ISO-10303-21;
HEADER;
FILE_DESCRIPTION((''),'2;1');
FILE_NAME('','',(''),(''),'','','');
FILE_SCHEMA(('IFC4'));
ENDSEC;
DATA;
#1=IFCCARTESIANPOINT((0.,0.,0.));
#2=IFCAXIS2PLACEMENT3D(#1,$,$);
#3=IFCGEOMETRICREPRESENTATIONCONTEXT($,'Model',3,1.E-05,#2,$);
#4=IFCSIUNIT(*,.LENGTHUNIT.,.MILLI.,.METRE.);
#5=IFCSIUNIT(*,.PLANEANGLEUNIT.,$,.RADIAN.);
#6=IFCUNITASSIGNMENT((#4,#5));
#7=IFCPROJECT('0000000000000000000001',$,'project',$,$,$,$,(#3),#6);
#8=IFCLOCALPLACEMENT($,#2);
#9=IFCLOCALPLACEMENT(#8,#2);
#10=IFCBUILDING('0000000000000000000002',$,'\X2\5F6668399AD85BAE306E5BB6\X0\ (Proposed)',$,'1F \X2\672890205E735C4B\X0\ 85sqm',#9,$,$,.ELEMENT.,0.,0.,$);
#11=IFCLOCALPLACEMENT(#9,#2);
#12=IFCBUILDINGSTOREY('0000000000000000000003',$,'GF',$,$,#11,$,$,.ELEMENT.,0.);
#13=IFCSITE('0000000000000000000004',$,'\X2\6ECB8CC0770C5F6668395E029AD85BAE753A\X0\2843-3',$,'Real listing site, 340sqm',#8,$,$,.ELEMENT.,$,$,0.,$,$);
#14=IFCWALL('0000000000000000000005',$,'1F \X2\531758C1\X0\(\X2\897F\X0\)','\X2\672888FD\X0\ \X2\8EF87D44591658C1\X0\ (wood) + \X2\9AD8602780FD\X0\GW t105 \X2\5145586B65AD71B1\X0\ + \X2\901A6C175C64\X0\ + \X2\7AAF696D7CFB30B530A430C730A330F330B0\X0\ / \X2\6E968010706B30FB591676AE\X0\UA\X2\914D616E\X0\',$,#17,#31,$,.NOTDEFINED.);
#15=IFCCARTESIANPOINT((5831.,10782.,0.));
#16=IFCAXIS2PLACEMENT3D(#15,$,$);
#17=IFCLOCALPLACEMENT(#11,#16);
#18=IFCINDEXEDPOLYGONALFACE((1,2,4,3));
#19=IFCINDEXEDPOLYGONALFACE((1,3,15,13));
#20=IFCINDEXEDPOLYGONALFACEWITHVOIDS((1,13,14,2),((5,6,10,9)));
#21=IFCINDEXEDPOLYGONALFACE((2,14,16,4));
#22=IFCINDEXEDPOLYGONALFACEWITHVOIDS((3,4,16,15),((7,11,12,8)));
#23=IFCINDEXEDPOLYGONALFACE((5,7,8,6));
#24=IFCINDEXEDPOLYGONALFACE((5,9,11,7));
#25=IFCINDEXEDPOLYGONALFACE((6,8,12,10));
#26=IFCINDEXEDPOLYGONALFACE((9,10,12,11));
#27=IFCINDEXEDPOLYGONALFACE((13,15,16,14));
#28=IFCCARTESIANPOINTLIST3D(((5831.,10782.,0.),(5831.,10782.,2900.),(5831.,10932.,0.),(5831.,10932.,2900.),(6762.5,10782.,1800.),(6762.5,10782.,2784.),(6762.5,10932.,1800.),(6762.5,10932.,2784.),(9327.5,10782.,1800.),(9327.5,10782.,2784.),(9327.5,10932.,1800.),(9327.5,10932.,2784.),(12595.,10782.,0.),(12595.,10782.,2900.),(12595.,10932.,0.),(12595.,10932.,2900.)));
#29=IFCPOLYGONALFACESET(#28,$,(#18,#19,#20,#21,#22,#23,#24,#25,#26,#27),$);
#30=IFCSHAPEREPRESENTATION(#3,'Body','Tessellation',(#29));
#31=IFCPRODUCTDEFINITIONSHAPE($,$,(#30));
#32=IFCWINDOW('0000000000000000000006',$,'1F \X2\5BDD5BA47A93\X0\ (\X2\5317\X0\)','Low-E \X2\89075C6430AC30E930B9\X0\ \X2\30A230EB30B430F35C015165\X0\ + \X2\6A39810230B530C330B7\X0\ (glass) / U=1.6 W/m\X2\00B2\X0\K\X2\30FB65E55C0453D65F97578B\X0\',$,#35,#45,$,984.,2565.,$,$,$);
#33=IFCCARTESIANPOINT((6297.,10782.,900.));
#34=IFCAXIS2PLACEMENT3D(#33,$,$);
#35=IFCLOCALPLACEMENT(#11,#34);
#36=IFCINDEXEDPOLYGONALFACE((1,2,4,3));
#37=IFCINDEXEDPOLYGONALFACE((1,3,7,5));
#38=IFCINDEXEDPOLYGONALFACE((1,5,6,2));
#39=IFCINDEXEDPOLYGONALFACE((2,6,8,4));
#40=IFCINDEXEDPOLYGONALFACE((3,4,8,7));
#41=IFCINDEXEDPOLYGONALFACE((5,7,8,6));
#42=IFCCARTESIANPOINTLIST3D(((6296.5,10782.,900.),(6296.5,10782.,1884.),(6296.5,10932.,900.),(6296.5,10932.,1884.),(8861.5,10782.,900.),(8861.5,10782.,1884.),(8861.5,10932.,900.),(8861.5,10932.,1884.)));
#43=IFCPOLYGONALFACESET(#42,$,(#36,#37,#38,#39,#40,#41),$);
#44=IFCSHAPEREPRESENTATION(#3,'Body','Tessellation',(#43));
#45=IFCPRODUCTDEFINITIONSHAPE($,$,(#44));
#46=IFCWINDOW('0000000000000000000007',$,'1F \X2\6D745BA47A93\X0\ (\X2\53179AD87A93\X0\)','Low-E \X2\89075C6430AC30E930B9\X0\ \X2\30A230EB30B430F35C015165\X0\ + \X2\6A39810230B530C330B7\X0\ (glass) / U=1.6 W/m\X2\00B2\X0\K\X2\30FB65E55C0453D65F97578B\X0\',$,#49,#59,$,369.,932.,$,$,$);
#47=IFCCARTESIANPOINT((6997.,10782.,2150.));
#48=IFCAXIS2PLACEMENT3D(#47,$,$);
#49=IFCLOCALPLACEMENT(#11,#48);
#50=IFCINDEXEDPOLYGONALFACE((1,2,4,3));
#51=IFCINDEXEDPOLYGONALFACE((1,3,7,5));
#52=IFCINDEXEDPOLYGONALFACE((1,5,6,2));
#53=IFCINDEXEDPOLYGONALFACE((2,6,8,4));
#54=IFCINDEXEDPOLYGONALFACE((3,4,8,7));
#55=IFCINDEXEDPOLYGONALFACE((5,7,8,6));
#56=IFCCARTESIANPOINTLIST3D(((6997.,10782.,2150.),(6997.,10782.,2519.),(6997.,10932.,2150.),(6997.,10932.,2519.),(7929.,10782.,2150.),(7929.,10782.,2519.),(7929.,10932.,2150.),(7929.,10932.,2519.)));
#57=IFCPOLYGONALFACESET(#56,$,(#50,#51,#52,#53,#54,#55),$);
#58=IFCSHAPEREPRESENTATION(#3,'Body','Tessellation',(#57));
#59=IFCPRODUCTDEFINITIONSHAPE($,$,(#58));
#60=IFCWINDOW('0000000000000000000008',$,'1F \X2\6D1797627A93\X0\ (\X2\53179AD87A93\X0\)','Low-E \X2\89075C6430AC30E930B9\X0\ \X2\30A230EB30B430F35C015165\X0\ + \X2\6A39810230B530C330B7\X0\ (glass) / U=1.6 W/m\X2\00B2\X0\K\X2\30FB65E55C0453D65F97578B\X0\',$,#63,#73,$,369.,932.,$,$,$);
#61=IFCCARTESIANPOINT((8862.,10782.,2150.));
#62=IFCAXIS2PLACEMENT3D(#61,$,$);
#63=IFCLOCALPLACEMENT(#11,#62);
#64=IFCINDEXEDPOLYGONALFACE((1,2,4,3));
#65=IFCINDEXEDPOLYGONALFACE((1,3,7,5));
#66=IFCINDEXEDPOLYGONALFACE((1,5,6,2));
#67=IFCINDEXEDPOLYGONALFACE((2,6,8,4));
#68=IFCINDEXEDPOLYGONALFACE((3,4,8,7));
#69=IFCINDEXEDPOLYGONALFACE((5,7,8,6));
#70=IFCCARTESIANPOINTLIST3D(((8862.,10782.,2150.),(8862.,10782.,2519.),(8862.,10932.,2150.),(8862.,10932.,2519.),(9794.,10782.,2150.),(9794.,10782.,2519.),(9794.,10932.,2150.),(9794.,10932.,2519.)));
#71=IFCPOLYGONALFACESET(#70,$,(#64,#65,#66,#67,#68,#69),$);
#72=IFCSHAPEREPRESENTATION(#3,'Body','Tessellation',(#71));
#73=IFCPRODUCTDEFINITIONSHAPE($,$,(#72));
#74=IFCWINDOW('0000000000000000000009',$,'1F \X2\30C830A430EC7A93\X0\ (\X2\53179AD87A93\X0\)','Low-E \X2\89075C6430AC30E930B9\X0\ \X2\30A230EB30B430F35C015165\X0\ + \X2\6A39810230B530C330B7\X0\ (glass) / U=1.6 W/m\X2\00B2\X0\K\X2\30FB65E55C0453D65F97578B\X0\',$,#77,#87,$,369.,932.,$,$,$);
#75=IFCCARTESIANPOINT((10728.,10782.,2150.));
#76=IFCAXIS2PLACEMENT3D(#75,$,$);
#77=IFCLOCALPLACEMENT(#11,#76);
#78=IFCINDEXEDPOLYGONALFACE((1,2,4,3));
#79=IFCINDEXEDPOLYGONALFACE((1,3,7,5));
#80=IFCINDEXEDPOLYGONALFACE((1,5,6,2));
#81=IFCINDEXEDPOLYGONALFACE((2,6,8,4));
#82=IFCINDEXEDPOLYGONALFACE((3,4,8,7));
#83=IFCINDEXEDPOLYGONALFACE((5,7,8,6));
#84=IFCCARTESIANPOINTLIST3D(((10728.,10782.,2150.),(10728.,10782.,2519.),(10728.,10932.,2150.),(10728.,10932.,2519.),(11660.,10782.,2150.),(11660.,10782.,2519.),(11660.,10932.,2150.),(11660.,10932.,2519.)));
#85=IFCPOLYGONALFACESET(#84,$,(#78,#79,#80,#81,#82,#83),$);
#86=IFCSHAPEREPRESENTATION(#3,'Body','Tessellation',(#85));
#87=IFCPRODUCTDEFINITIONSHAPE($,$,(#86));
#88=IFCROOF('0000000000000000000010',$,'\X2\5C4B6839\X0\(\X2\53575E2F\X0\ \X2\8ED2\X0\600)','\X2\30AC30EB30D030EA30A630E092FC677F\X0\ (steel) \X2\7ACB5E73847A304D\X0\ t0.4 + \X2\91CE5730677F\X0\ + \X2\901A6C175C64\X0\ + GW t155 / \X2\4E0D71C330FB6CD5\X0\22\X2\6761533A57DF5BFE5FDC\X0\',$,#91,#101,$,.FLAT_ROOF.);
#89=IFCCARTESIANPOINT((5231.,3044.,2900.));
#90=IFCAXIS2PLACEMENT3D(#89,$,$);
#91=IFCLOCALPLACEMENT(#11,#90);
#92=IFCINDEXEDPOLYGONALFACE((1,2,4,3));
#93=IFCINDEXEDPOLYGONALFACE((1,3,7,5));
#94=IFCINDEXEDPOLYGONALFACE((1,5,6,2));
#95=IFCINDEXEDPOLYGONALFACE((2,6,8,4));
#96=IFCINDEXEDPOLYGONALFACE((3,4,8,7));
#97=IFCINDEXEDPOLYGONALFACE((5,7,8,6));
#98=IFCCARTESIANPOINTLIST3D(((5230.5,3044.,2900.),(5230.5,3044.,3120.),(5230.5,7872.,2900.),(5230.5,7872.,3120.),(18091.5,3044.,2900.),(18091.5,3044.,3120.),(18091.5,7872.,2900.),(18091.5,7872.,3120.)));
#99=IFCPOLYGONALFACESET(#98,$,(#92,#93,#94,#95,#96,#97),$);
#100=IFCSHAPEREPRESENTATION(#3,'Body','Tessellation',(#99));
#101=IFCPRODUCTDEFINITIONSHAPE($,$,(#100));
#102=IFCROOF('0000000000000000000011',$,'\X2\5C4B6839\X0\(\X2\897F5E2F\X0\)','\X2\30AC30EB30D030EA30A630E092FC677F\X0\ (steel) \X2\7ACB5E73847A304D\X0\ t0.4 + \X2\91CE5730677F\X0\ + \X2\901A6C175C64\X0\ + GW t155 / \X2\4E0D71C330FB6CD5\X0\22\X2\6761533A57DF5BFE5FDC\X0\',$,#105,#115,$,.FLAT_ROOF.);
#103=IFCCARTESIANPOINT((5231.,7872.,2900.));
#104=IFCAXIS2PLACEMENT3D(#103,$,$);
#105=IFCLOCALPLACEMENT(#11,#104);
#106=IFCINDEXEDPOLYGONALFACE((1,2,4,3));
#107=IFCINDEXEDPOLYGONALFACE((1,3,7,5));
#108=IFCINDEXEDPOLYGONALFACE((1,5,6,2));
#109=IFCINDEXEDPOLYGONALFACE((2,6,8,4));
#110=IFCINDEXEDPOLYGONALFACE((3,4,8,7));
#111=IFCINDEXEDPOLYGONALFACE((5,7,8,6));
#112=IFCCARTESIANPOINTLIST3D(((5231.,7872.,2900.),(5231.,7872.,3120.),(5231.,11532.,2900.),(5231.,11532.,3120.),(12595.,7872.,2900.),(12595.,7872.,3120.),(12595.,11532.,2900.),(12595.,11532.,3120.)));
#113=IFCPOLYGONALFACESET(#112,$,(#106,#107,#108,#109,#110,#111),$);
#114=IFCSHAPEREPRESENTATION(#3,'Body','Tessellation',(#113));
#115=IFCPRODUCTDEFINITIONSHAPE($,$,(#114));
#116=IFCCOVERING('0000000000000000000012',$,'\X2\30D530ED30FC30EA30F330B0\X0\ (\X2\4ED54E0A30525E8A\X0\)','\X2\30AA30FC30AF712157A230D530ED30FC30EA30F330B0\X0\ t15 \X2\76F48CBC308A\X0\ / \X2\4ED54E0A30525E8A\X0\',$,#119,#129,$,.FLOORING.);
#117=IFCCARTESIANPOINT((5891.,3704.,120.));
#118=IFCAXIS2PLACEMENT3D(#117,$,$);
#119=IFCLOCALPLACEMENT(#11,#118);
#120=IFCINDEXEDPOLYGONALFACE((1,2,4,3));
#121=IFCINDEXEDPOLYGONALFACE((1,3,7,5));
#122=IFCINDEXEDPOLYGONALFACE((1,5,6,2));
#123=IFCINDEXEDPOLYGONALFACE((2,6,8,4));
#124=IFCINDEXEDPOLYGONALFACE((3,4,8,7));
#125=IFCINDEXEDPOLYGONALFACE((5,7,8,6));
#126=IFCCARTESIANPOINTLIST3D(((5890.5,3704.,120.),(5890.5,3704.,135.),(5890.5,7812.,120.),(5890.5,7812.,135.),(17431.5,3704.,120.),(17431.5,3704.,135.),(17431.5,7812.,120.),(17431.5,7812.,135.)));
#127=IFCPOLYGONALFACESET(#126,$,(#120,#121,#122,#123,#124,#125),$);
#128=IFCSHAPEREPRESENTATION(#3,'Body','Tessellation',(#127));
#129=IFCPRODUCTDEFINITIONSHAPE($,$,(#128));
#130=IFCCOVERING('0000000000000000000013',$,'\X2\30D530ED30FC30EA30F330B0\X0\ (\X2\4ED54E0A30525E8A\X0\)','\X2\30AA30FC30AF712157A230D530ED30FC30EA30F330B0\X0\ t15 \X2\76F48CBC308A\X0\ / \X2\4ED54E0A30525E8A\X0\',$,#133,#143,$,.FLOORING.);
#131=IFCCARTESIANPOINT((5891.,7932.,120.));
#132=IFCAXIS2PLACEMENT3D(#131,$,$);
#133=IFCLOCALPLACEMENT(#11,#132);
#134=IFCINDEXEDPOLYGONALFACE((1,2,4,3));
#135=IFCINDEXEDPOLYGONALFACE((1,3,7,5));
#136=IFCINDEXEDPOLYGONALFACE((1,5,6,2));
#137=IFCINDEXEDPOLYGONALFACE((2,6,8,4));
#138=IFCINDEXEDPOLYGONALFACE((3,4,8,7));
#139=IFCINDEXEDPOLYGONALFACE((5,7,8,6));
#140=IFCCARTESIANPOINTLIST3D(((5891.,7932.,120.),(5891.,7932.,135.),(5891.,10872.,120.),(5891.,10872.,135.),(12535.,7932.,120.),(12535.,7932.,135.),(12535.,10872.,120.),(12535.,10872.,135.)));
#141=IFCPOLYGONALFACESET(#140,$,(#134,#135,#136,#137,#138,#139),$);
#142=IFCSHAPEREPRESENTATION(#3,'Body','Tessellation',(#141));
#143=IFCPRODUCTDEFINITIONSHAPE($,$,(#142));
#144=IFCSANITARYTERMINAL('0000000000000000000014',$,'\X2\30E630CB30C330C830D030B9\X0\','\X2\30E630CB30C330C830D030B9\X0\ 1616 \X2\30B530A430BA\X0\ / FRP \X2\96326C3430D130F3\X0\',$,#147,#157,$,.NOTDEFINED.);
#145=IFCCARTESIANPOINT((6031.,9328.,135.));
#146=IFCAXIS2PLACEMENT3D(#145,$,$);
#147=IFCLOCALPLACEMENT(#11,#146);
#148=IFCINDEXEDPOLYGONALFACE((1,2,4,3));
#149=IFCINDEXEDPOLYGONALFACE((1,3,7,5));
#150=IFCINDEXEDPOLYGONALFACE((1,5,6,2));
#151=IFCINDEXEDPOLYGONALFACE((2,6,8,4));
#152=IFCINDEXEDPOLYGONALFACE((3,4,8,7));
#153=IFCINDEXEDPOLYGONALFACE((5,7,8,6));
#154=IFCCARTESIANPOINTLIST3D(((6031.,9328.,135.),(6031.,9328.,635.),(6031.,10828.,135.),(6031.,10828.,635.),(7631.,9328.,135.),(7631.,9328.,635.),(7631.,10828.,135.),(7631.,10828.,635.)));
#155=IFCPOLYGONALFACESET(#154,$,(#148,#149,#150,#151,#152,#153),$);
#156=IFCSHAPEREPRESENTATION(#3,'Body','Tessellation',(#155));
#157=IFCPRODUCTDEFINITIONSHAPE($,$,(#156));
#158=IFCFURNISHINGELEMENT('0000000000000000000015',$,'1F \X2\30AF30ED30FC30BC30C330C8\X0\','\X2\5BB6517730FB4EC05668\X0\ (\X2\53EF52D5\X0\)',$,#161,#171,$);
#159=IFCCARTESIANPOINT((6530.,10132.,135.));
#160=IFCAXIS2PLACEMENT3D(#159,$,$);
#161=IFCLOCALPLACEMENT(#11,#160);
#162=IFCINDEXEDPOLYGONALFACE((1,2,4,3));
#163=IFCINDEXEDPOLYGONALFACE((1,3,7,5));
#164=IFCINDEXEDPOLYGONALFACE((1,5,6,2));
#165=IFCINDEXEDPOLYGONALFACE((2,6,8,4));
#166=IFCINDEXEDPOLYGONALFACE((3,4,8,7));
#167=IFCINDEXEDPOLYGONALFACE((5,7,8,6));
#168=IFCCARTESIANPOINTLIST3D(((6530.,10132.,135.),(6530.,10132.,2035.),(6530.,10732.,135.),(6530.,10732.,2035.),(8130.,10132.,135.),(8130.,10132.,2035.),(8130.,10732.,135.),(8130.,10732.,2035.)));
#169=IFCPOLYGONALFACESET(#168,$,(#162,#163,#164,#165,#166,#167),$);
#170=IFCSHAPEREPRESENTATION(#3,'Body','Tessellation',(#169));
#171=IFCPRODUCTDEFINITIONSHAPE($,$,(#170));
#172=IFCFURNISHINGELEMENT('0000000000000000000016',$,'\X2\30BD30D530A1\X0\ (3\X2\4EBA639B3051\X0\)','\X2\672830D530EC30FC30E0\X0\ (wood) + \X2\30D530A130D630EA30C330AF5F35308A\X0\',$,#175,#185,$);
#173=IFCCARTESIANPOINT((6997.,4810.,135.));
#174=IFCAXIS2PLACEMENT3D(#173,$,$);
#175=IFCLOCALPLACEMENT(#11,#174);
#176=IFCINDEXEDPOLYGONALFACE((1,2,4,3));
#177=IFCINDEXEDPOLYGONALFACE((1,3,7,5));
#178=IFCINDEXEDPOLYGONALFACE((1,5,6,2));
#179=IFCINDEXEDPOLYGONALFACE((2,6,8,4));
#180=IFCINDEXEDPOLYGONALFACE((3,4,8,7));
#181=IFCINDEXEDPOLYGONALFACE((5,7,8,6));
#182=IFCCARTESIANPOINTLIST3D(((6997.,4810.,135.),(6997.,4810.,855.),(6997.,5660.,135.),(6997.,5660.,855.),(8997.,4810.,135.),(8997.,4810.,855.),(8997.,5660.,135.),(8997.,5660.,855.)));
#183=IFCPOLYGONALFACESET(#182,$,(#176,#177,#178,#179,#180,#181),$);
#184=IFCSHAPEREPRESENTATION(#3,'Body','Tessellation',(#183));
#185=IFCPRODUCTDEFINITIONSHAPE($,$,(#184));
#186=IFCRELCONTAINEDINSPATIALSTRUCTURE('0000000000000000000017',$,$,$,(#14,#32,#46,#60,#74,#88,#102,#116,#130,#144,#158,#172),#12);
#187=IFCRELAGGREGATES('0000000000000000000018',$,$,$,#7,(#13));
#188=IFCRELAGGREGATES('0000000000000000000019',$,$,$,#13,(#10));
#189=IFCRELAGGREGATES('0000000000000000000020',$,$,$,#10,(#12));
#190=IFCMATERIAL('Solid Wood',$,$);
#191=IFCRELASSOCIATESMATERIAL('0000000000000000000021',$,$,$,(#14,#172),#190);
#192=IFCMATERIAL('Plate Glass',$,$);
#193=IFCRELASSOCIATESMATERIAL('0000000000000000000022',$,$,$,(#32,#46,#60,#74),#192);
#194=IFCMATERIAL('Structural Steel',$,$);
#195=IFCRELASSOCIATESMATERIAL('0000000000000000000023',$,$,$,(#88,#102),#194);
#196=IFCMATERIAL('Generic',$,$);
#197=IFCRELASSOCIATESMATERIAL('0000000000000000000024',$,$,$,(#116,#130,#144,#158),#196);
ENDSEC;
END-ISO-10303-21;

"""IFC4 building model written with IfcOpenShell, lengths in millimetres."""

from ifc_helpers import new_model, si_unit, frame, frame_2d, origin, place, context, project, spatial, rectangle, extrude, material, element, fill, save


model = new_model("IFC4")

# Units and contexts
model_context = context("Model", 3, precision=1e-05, world=origin())
ifc_project = project(units=[si_unit("LENGTHUNIT", "METRE", prefix="MILLI"), si_unit("PLANEANGLEUNIT", "RADIAN")], contexts=[model_context])

# Site, building, storey
site_placement = place(None, origin())
site = spatial("IfcSite", under=ifc_project, at=site_placement, Name="滋賀県彦根市高宮町2843-3", ObjectType="Real listing site, 340sqm", CompositionType="ELEMENT", RefElevation=0.0)
building_placement = place(site_placement, origin())
building = spatial("IfcBuilding", under=site, at=building_placement, Name="彦根高宮の家 (Proposed)", ObjectType="1F 木造平屋 85sqm", CompositionType="ELEMENT", ElevationOfRefHeight=0.0, ElevationOfTerrain=0.0)
storey_placement = place(building_placement, origin())
storey = spatial("IfcBuildingStorey", under=building, at=storey_placement, Name="GF", CompositionType="ELEMENT", Elevation=0.0)

# Shared definitions
ifc_material_1 = material(Name="Solid Wood")

# Shared definitions
ifc_material_2 = material(Name="Plate Glass")

# Wall, openings, windows
wall_1_placement = place(storey_placement, frame((5831.0, 10782.0, 0.0)))
wall_1 = element("IfcWall", 1, at=wall_1_placement, inside=storey, material=ifc_material_1, Name="1F 北壁(西)", Description="木製 軸組外壁 (wood) + 高性能GW t105 充填断熱 + 通気層 + 窯業系サイディング / 準耐火・外皮UA配慮", PredefinedType="NOTDEFINED", context=model_context, shape_type="SweptSolid", body=[
    extrude(rectangle(XDim=6764.0, YDim=150.0, at=frame_2d((3382.0, 75.0))), frame((5831.0, 10782.0, 0.0)), (0.0, 0.0, 1.0), 2900.0),
])
opening_1_placement = place(storey_placement, frame((6297.0, 10782.0, 900.0)))
opening_1 = element("IfcOpeningElement", 2, at=opening_1_placement, cuts=wall_1, PredefinedType="NOTDEFINED", context=model_context, shape_type="SweptSolid", body=[
    extrude(rectangle(XDim=2565.0, YDim=150.0, at=frame_2d((1282.0, 75.0))), frame((6297.0, 10782.0, 900.0)), (0.0, 0.0, 1.0), 984.0),
])
opening_2_placement = place(storey_placement, frame((6997.0, 10782.0, 2150.0)))
opening_2 = element("IfcOpeningElement", 3, at=opening_2_placement, cuts=wall_1, PredefinedType="NOTDEFINED", context=model_context, shape_type="SweptSolid", body=[
    extrude(rectangle(XDim=932.0, YDim=150.0, at=frame_2d((466.0, 75.0))), frame((6997.0, 10782.0, 2150.0)), (0.0, 0.0, 1.0), 369.0),
])
opening_3_placement = place(storey_placement, frame((8862.0, 10782.0, 2150.0)))
opening_3 = element("IfcOpeningElement", 4, at=opening_3_placement, cuts=wall_1, PredefinedType="NOTDEFINED", context=model_context, shape_type="SweptSolid", body=[
    extrude(rectangle(XDim=932.0, YDim=150.0, at=frame_2d((466.0, 75.0))), frame((8862.0, 10782.0, 2150.0)), (0.0, 0.0, 1.0), 369.0),
])
opening_4_placement = place(storey_placement, frame((10728.0, 10782.0, 2150.0)))
opening_4 = element("IfcOpeningElement", 5, at=opening_4_placement, cuts=wall_1, PredefinedType="NOTDEFINED", context=model_context, shape_type="SweptSolid", body=[
    extrude(rectangle(XDim=932.0, YDim=150.0, at=frame_2d((466.0, 75.0))), frame((10728.0, 10782.0, 2150.0)), (0.0, 0.0, 1.0), 369.0),
])
window_1_placement = place(storey_placement, frame((6297.0, 10782.0, 900.0)))
window_1 = element("IfcWindow", 6, at=window_1_placement, inside=storey, material=ifc_material_2, Name="1F 寝室窓 (北)", Description="Low-E 複層ガラス アルゴン封入 + 樹脂サッシ (glass) / U=1.6 W/m²K・日射取得型", OverallHeight=984.0, OverallWidth=2565.0, context=model_context, shape_type="SweptSolid", body=[
    extrude(rectangle(XDim=2565.0, YDim=150.0, at=frame_2d((1282.0, 75.0))), frame((6297.0, 10782.0, 900.0)), (0.0, 0.0, 1.0), 984.0),
])
fill(opening_1, window_1)
window_2_placement = place(storey_placement, frame((6997.0, 10782.0, 2150.0)))
window_2 = element("IfcWindow", 7, at=window_2_placement, inside=storey, material=ifc_material_2, Name="1F 浴室窓 (北高窓)", Description="Low-E 複層ガラス アルゴン封入 + 樹脂サッシ (glass) / U=1.6 W/m²K・日射取得型", OverallHeight=369.0, OverallWidth=932.0, context=model_context, shape_type="SweptSolid", body=[
    extrude(rectangle(XDim=932.0, YDim=150.0, at=frame_2d((466.0, 75.0))), frame((6997.0, 10782.0, 2150.0)), (0.0, 0.0, 1.0), 369.0),
])
fill(opening_2, window_2)
window_3_placement = place(storey_placement, frame((8862.0, 10782.0, 2150.0)))
window_3 = element("IfcWindow", 8, at=window_3_placement, inside=storey, material=ifc_material_2, Name="1F 洗面窓 (北高窓)", Description="Low-E 複層ガラス アルゴン封入 + 樹脂サッシ (glass) / U=1.6 W/m²K・日射取得型", OverallHeight=369.0, OverallWidth=932.0, context=model_context, shape_type="SweptSolid", body=[
    extrude(rectangle(XDim=932.0, YDim=150.0, at=frame_2d((466.0, 75.0))), frame((8862.0, 10782.0, 2150.0)), (0.0, 0.0, 1.0), 369.0),
])
fill(opening_3, window_3)
window_4_placement = place(storey_placement, frame((10728.0, 10782.0, 2150.0)))
window_4 = element("IfcWindow", 9, at=window_4_placement, inside=storey, material=ifc_material_2, Name="1F トイレ窓 (北高窓)", Description="Low-E 複層ガラス アルゴン封入 + 樹脂サッシ (glass) / U=1.6 W/m²K・日射取得型", OverallHeight=369.0, OverallWidth=932.0, context=model_context, shape_type="SweptSolid", body=[
    extrude(rectangle(XDim=932.0, YDim=150.0, at=frame_2d((466.0, 75.0))), frame((10728.0, 10782.0, 2150.0)), (0.0, 0.0, 1.0), 369.0),
])
fill(opening_4, window_4)

# Roofs
ifc_material_3 = material(Name="Structural Steel")
roof_1_placement = place(storey_placement, frame((5231.0, 3044.0, 2900.0)))
element("IfcRoof", 10, at=roof_1_placement, inside=storey, material=ifc_material_3, Name="屋根(南帯 軒600)", Description="ガルバリウム鋼板 (steel) 立平葺き t0.4 + 野地板 + 通気層 + GW t155 / 不燃・法22条区域対応", PredefinedType="FLAT_ROOF", context=model_context, shape_type="SweptSolid", body=[
    extrude(rectangle(XDim=12861.0, YDim=4828.0, at=frame_2d((6430.0, 2414.0))), frame((5231.0, 3044.0, 2900.0)), (0.0, 0.0, 1.0), 220.0),
])
roof_2_placement = place(storey_placement, frame((5231.0, 7872.0, 2900.0)))
element("IfcRoof", 11, at=roof_2_placement, inside=storey, material=ifc_material_3, Name="屋根(西帯)", Description="ガルバリウム鋼板 (steel) 立平葺き t0.4 + 野地板 + 通気層 + GW t155 / 不燃・法22条区域対応", PredefinedType="FLAT_ROOF", context=model_context, shape_type="SweptSolid", body=[
    extrude(rectangle(XDim=7364.0, YDim=3660.0, at=frame_2d((3682.0, 1830.0))), frame((5231.0, 7872.0, 2900.0)), (0.0, 0.0, 1.0), 220.0),
])

# Coverings
ifc_material_4 = material(Name="Generic")
covering_1_placement = place(storey_placement, frame((5891.0, 3704.0, 120.0)))
element("IfcCovering", 12, at=covering_1_placement, inside=storey, material=ifc_material_4, Name="フローリング (仕上げ床)", Description="オーク無垢フローリング t15 直貼り / 仕上げ床", PredefinedType="FLOORING", context=model_context, shape_type="SweptSolid", body=[
    extrude(rectangle(XDim=11541.0, YDim=4108.0, at=frame_2d((5770.0, 2054.0))), frame((5891.0, 3704.0, 120.0)), (0.0, 0.0, 1.0), 15.0),
])
covering_2_placement = place(storey_placement, frame((5891.0, 7932.0, 120.0)))
element("IfcCovering", 13, at=covering_2_placement, inside=storey, material=ifc_material_4, Name="フローリング (仕上げ床)", Description="オーク無垢フローリング t15 直貼り / 仕上げ床", PredefinedType="FLOORING", context=model_context, shape_type="SweptSolid", body=[
    extrude(rectangle(XDim=6644.0, YDim=2940.0, at=frame_2d((3322.0, 1470.0))), frame((5891.0, 7932.0, 120.0)), (0.0, 0.0, 1.0), 15.0),
])

# Sanitary terminal
sanitary_terminal_placement = place(storey_placement, frame((6031.0, 9328.0, 135.0)))
element("IfcSanitaryTerminal", 14, at=sanitary_terminal_placement, inside=storey, material=ifc_material_4, Name="ユニットバス", Description="ユニットバス 1616 サイズ / FRP 防水パン", PredefinedType="NOTDEFINED", context=model_context, shape_type="SweptSolid", body=[
    extrude(rectangle(XDim=1600.0, YDim=1500.0, at=frame_2d((800.0, 750.0))), frame((6031.0, 9328.0, 135.0)), (0.0, 0.0, 1.0), 500.0),
])

# Furnishing elements
furnishing_1_placement = place(storey_placement, frame((6530.0, 10132.0, 135.0)))
element("IfcFurnishingElement", 15, at=furnishing_1_placement, inside=storey, material=ifc_material_4, Name="1F クローゼット", Description="家具・什器 (可動)", context=model_context, shape_type="SweptSolid", body=[
    extrude(rectangle(XDim=1600.0, YDim=600.0, at=frame_2d((800.0, 300.0))), frame((6530.0, 10132.0, 135.0)), (0.0, 0.0, 1.0), 1900.0),
])
furnishing_2_placement = place(storey_placement, frame((6997.0, 4810.0, 135.0)))
element("IfcFurnishingElement", 16, at=furnishing_2_placement, inside=storey, material=ifc_material_1, Name="ソファ (3人掛け)", Description="木フレーム (wood) + ファブリック張り", context=model_context, shape_type="SweptSolid", body=[
    extrude(rectangle(XDim=2000.0, YDim=850.0, at=frame_2d((1000.0, 425.0))), frame((6997.0, 4810.0, 135.0)), (0.0, 0.0, 1.0), 720.0),
])

save(model, "model.ifc")
